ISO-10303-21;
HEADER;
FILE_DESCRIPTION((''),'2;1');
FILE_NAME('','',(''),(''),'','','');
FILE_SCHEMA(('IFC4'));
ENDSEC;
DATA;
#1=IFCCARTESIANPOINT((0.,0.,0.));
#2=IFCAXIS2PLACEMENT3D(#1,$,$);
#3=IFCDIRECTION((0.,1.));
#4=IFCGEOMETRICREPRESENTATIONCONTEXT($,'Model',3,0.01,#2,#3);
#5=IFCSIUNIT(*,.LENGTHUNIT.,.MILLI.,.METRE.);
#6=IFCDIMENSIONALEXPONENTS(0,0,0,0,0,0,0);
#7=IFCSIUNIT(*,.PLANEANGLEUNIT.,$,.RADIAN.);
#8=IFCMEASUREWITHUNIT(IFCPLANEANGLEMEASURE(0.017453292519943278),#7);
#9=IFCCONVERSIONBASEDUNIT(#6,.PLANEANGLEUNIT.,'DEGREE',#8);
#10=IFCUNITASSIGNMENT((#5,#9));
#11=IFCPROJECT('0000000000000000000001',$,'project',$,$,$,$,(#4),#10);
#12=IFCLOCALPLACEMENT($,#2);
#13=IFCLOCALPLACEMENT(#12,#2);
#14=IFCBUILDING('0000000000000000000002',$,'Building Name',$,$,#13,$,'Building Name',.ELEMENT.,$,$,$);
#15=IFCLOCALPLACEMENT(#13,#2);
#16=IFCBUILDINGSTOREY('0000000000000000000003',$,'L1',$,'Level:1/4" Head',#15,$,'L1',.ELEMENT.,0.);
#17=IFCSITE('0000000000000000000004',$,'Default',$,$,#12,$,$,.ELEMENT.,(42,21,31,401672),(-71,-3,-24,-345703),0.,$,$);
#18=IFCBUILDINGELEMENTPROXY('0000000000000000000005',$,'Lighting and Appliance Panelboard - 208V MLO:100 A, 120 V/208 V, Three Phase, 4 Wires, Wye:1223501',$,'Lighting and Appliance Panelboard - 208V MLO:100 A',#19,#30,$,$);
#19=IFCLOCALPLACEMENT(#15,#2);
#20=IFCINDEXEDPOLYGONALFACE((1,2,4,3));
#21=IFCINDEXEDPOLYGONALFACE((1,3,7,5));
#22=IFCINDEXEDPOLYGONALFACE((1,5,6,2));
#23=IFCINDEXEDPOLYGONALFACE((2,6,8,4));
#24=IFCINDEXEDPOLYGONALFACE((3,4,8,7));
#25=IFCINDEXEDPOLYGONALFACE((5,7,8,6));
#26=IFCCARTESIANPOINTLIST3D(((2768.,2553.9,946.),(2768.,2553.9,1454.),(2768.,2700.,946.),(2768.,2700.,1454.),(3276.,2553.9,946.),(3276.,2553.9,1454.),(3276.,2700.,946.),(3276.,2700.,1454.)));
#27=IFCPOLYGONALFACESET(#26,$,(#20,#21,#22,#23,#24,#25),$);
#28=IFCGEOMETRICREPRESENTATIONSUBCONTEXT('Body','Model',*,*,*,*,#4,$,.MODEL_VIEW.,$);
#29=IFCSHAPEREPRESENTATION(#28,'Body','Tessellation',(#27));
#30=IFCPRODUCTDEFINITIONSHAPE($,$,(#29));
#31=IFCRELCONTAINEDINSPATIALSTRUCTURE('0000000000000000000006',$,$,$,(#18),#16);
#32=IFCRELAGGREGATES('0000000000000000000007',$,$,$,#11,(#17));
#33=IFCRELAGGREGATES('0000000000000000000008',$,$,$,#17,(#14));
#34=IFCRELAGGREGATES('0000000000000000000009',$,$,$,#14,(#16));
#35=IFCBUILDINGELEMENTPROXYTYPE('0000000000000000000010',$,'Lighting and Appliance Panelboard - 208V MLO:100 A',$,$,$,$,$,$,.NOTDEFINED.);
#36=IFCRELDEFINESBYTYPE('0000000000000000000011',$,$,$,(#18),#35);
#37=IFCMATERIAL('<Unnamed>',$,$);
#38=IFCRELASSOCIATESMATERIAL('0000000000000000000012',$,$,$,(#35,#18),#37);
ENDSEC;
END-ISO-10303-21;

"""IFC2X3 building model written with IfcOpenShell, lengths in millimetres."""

from ifc_helpers import new_model, entity, si_unit, converted_unit, direction, frame, origin, origin_2d_with_axis, place, context, subcontext, project, spatial, rectangle, extrude, source, transform, mapped, material, type_object, type_shapes, element, save


model = new_model("IFC2X3")

# Units and contexts
model_context = context("Model", 3, precision=0.01, world=origin(), true_north=direction((0.0, 1.0)))
body_context = subcontext(model_context, "Body", "Model", "MODEL_VIEW")
ifc_project = project(units=[si_unit("LENGTHUNIT", "METRE", prefix="MILLI"), converted_unit("PLANEANGLEUNIT", "DEGREE", entity("IfcPlaneAngleMeasure", 0.017453292519943278), si_unit("PLANEANGLEUNIT", "RADIAN"), dimensions=[0, 0, 0, 0, 0, 0, 0])], contexts=[model_context])

# Site, building, storey
site_placement = place(None, origin())
site = spatial("IfcSite", under=ifc_project, at=site_placement, Name="Default", CompositionType="ELEMENT", RefLatitude=(42, 21, 31, 401672), RefLongitude=(-71, -3, -24, -345703), RefElevation=0.0)
building_placement = place(site_placement, origin())
building = spatial("IfcBuilding", under=site, at=building_placement, Name="Building Name", LongName="Building Name", CompositionType="ELEMENT")
storey_placement = place(building_placement, origin())
storey = spatial("IfcBuildingStorey", under=building, at=storey_placement, Name="L1", ObjectType="Level:1/4\" Head", LongName="L1", CompositionType="ELEMENT", Elevation=0.0)

# Building element proxy
ifc_material = material(Name="<Unnamed>")
building_element_proxy_type_1 = type_object("IfcBuildingElementProxyType", Name="Lighting and Appliance Panelboard - 208V MLO:100 A", PredefinedType="NOTDEFINED", material=ifc_material)
shared_shape_1 = source(origin(), body_context, "Body", "SweptSolid", [
    extrude(rectangle(XDim=508.0, YDim=508.0, at=origin_2d_with_axis()), frame((0.0, 0.0, -146.1), z_axis=(0.0, 0.0, 1.0), x_axis=(-1.0, 0.0, 0.0)), (0.0, 0.0, 1.0), 146.1),
])
type_shapes(building_element_proxy_type_1, [shared_shape_1])
proxy_placement = place(storey_placement, frame((3022.0, 2700.0, 1200.0), z_axis=(0.0, 1.0, 0.0), x_axis=(-1.0, 0.0, 0.0)))
element("IfcBuildingElementProxy", 1, at=proxy_placement, inside=storey, type_object=building_element_proxy_type_1, material=ifc_material, Name="Lighting and Appliance Panelboard - 208V MLO:100 A, 120 V/208 V, Three Phase, 4 Wires, Wye:1223501", ObjectType="Lighting and Appliance Panelboard - 208V MLO:100 A", context=body_context, shape_type="MappedRepresentation", body=[
    mapped(shared_shape_1, transform((0.0, 0.0, 0.0), scale=1.0)),
])

save(model, "model.ifc")
